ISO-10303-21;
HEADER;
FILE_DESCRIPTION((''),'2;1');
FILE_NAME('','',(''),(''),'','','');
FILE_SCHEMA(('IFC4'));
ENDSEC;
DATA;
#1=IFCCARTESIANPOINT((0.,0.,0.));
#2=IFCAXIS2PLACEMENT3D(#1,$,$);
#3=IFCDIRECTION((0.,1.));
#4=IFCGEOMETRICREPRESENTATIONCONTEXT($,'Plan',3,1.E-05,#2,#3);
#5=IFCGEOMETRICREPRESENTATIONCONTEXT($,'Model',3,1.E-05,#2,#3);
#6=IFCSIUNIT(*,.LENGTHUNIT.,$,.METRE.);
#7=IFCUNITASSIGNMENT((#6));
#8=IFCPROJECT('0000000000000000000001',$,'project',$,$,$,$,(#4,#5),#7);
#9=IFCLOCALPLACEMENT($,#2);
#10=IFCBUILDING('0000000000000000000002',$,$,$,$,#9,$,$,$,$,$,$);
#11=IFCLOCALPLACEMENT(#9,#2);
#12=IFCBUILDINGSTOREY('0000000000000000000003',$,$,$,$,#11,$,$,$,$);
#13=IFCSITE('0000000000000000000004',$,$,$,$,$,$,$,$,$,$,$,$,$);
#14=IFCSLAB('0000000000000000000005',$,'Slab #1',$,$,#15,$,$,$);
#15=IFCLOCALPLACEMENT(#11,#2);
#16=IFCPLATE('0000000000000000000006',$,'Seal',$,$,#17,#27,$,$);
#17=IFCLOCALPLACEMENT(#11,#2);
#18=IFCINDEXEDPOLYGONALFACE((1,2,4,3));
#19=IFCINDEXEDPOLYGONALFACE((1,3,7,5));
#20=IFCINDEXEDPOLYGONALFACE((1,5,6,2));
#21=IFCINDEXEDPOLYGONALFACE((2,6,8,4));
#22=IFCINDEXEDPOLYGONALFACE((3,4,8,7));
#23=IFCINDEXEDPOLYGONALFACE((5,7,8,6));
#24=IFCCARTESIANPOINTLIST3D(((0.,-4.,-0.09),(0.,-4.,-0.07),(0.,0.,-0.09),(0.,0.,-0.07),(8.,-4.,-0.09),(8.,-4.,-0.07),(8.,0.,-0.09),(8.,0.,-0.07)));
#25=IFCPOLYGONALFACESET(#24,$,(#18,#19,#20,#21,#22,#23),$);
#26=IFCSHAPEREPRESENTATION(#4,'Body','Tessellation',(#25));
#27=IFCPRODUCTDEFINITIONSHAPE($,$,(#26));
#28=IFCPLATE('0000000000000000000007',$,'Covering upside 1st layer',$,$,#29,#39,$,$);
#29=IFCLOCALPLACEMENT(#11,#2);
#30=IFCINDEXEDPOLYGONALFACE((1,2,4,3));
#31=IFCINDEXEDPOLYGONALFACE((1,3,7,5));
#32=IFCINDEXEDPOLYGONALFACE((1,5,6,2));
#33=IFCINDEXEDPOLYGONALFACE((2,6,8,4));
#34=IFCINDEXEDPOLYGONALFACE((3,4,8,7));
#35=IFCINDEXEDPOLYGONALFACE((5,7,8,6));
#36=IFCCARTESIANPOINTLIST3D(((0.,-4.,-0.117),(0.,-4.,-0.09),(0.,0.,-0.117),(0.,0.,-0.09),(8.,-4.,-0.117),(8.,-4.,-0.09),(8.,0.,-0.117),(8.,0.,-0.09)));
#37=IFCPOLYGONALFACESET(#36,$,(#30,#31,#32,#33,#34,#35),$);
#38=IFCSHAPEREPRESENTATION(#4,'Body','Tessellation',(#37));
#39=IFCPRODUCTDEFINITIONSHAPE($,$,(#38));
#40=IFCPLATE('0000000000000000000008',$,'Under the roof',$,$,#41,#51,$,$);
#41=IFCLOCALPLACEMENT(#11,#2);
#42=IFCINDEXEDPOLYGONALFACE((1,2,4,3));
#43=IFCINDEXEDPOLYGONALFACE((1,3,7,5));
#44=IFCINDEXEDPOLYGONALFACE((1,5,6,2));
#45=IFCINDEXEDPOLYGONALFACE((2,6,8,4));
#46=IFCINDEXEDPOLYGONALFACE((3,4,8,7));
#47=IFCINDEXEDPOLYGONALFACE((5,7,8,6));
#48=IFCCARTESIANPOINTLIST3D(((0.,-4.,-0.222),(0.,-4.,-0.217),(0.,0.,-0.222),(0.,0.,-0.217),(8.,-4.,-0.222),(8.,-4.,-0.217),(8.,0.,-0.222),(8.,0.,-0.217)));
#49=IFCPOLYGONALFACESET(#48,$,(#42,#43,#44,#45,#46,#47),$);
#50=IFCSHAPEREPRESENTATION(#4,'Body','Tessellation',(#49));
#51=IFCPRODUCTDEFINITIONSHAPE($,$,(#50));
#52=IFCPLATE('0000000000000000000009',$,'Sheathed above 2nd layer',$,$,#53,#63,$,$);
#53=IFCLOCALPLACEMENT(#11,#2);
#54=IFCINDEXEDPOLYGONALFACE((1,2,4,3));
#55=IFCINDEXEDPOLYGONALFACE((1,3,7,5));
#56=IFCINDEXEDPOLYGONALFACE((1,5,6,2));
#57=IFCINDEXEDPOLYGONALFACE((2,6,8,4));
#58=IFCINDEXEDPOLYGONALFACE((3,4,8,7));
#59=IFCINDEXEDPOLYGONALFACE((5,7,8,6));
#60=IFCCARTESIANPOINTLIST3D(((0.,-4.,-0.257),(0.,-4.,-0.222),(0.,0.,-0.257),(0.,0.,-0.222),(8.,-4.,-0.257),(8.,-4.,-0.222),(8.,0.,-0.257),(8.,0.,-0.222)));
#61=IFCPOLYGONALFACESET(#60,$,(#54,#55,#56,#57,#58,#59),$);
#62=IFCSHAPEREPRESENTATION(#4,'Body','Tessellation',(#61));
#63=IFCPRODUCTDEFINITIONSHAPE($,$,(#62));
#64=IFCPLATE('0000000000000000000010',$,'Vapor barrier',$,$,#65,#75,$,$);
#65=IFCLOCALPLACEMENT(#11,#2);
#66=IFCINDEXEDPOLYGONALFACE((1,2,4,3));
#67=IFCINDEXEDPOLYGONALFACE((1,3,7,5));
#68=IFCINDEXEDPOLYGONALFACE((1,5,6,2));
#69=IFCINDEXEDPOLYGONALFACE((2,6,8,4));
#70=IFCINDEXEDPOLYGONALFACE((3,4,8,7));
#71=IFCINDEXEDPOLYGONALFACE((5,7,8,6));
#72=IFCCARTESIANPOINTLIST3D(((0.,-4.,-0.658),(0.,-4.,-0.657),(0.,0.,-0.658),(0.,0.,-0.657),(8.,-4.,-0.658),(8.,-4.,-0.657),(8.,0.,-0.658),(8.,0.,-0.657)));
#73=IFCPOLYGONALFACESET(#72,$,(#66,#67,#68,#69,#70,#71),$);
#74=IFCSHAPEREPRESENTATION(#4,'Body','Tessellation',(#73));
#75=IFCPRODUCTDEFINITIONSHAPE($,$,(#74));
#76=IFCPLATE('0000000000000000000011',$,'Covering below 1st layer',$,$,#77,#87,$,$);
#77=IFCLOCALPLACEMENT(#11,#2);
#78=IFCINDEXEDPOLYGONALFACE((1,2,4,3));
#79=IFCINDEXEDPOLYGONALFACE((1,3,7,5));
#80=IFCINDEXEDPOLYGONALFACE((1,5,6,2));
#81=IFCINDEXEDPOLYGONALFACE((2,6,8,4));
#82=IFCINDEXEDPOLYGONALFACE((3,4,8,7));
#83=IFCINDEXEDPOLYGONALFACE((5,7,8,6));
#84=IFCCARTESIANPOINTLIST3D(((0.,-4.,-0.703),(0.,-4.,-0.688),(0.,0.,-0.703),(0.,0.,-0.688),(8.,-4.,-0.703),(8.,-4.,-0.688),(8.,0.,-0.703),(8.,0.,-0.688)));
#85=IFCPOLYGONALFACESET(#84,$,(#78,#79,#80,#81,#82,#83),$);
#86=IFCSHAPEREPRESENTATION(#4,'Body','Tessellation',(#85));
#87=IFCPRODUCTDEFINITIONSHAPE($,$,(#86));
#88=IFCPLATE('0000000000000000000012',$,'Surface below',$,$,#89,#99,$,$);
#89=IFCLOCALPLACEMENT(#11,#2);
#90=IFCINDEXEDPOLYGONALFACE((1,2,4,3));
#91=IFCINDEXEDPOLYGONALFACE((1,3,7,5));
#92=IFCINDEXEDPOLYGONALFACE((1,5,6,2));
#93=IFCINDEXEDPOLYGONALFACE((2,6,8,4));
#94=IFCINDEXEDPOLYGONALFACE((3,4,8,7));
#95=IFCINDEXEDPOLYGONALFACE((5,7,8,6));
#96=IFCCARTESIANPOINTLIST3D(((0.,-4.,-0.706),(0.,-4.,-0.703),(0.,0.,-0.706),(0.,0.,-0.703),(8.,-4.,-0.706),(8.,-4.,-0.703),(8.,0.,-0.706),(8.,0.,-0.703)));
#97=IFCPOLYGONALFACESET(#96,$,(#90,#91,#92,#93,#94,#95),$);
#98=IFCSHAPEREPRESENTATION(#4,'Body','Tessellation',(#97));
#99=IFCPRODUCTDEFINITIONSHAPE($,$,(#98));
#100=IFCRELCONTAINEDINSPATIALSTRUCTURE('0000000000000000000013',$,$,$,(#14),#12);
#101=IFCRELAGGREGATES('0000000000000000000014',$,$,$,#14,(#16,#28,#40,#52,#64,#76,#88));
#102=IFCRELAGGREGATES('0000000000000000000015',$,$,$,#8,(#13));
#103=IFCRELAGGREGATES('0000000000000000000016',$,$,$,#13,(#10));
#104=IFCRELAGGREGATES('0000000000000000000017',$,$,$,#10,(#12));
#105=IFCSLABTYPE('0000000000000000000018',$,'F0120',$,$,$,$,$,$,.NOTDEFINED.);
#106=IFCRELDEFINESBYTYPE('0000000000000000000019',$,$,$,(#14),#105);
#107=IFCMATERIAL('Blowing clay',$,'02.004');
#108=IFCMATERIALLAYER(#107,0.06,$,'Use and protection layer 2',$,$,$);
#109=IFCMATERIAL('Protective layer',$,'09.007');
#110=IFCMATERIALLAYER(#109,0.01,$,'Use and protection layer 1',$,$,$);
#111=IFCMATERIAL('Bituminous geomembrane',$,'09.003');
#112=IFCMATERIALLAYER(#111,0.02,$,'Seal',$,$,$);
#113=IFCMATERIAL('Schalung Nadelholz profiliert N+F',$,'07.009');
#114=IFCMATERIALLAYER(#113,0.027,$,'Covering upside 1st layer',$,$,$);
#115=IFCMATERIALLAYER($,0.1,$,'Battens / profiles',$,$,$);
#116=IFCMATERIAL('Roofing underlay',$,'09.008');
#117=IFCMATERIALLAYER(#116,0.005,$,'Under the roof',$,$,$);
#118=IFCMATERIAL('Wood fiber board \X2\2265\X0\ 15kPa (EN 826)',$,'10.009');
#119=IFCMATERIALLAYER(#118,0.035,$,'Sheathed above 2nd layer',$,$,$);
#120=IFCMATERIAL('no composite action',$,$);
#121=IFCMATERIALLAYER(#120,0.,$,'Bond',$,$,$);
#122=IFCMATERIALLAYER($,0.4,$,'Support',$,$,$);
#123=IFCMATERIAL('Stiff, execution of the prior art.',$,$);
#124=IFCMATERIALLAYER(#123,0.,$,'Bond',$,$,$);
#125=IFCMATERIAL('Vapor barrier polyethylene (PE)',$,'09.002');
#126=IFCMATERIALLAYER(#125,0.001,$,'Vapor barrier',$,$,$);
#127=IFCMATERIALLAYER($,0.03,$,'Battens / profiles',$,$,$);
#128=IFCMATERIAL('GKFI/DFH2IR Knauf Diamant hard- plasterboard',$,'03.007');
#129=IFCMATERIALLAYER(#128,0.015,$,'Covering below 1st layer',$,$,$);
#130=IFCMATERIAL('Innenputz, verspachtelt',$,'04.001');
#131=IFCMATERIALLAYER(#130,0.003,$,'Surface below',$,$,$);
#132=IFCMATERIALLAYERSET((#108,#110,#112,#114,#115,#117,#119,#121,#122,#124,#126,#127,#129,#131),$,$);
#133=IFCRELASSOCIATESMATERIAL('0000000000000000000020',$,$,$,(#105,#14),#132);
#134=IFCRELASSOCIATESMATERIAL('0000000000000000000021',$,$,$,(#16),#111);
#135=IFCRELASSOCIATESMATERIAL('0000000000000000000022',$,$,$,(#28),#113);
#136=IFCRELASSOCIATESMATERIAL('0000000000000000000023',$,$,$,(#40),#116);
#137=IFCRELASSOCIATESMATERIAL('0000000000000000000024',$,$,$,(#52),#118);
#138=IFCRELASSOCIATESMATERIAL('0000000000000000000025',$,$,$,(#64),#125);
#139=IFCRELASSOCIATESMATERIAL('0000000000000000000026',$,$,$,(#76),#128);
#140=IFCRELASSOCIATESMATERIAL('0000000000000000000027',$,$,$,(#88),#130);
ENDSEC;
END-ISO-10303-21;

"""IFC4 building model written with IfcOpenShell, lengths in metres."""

from ifc_helpers import new_model, si_unit, direction, frame, frame_2d, origin, place, context, project, spatial, rectangle, extrude, material, layer, layer_set, type_object, element, aggregate, save


model = new_model("IFC4")

# Units and contexts
plan_context = context("Plan", 3, precision=1e-05, world=origin(), true_north=direction((0.0, 1.0)))
model_context = context("Model", 3, precision=1e-05, world=origin(), true_north=direction((0.0, 1.0)))
ifc_project = project(units=[si_unit("LENGTHUNIT", "METRE")], contexts=[plan_context, model_context])

# Site, building, storey
site = spatial("IfcSite", under=ifc_project)
building_placement = place(None, origin())
building = spatial("IfcBuilding", under=site, at=building_placement)
storey_placement = place(building_placement, origin())
storey = spatial("IfcBuildingStorey", under=building, at=storey_placement)

# Slab, plates
ifc_material_1 = material(Name="Blowing clay", Category="02.004")
ifc_layer_1 = layer(ifc_material_1, 0.06, Name="Use and protection layer 2")
ifc_material_2 = material(Name="Protective layer", Category="09.007")
ifc_layer_2 = layer(ifc_material_2, 0.01, Name="Use and protection layer 1")
ifc_material_3 = material(Name="Bituminous geomembrane", Category="09.003")
ifc_layer_3 = layer(ifc_material_3, 0.02, Name="Seal")
ifc_material_4 = material(Name="Schalung Nadelholz profiliert N+F", Category="07.009")
ifc_layer_4 = layer(ifc_material_4, 0.027, Name="Covering upside 1st layer")
ifc_layer_5 = layer(None, 0.1, Name="Battens / profiles")
ifc_material_5 = material(Name="Roofing underlay", Category="09.008")
ifc_layer_6 = layer(ifc_material_5, 0.005, Name="Under the roof")
ifc_material_6 = material(Name="Wood fiber board ≥ 15kPa (EN 826)", Category="10.009")
ifc_layer_7 = layer(ifc_material_6, 0.035, Name="Sheathed above 2nd layer")
ifc_material_7 = material(Name="no composite action")
ifc_layer_8 = layer(ifc_material_7, 0.0, Name="Bond")
ifc_layer_9 = layer(None, 0.4, Name="Support")
ifc_material_8 = material(Name="Stiff, execution of the prior art.")
ifc_layer_10 = layer(ifc_material_8, 0.0, Name="Bond")
ifc_material_9 = material(Name="Vapor barrier polyethylene (PE)", Category="09.002")
ifc_layer_11 = layer(ifc_material_9, 0.001, Name="Vapor barrier")
ifc_layer_12 = layer(None, 0.03, Name="Battens / profiles")
ifc_material_10 = material(Name="GKFI/DFH2IR Knauf Diamant hard- plasterboard", Category="03.007")
ifc_layer_13 = layer(ifc_material_10, 0.015, Name="Covering below 1st layer")
ifc_material_11 = material(Name="Innenputz, verspachtelt", Category="04.001")
ifc_layer_14 = layer(ifc_material_11, 0.003, Name="Surface below")
ifc_layer_set = layer_set([ifc_layer_1, ifc_layer_2, ifc_layer_3, ifc_layer_4, ifc_layer_5, ifc_layer_6, ifc_layer_7, ifc_layer_8, ifc_layer_9, ifc_layer_10, ifc_layer_11, ifc_layer_12, ifc_layer_13, ifc_layer_14])
slab_type = type_object("IfcSlabType", Name="F0120", PredefinedType="NOTDEFINED", material=ifc_layer_set)
slab_placement = place(None, frame((0.0, 0.0, 0.0), z_axis=(0.0, 0.0, -1.0), x_axis=(1.0, 0.0, 0.0)))
slab = element("IfcSlab", 1, at=slab_placement, inside=storey, type_object=slab_type, material=ifc_layer_set, Name="Slab #1")
plate_1_placement = place(slab_placement, origin())
plate_1 = element("IfcPlate", 2, at=plate_1_placement, material=ifc_material_3, Name="Seal", context=plan_context, shape_type="SweptSolid", body=[
    extrude(rectangle(XDim=8.0, YDim=4.0, at=frame_2d((4.0, 2.0), x_axis=(1.0, 0.0))), frame((0.0, 0.0, 0.07), z_axis=(0.0, 0.0, 1.0), x_axis=(1.0, 0.0, 0.0)), (0.0, 0.0, 1.0), 0.02),
])
plate_2_placement = place(slab_placement, origin())
plate_2 = element("IfcPlate", 3, at=plate_2_placement, material=ifc_material_4, Name="Covering upside 1st layer", context=plan_context, shape_type="SweptSolid", body=[
    extrude(rectangle(XDim=8.0, YDim=4.0, at=frame_2d((4.0, 2.0), x_axis=(1.0, 0.0))), frame((0.0, 0.0, 0.09), z_axis=(0.0, 0.0, 1.0), x_axis=(1.0, 0.0, 0.0)), (0.0, 0.0, 1.0), 0.027),
])
plate_3_placement = place(slab_placement, origin())
plate_3 = element("IfcPlate", 4, at=plate_3_placement, material=ifc_material_5, Name="Under the roof", context=plan_context, shape_type="SweptSolid", body=[
    extrude(rectangle(XDim=8.0, YDim=4.0, at=frame_2d((4.0, 2.0), x_axis=(1.0, 0.0))), frame((0.0, 0.0, 0.217), z_axis=(0.0, 0.0, 1.0), x_axis=(1.0, 0.0, 0.0)), (0.0, 0.0, 1.0), 0.005),
])
plate_4_placement = place(slab_placement, origin())
plate_4 = element("IfcPlate", 5, at=plate_4_placement, material=ifc_material_6, Name="Sheathed above 2nd layer", context=plan_context, shape_type="SweptSolid", body=[
    extrude(rectangle(XDim=8.0, YDim=4.0, at=frame_2d((4.0, 2.0), x_axis=(1.0, 0.0))), frame((0.0, 0.0, 0.222), z_axis=(0.0, 0.0, 1.0), x_axis=(1.0, 0.0, 0.0)), (0.0, 0.0, 1.0), 0.035),
])
plate_5_placement = place(slab_placement, origin())
plate_5 = element("IfcPlate", 6, at=plate_5_placement, material=ifc_material_9, Name="Vapor barrier", context=plan_context, shape_type="SweptSolid", body=[
    extrude(rectangle(XDim=8.0, YDim=4.0, at=frame_2d((4.0, 2.0), x_axis=(1.0, 0.0))), frame((0.0, 0.0, 0.657), z_axis=(0.0, 0.0, 1.0), x_axis=(1.0, 0.0, 0.0)), (0.0, 0.0, 1.0), 0.001),
])
plate_6_placement = place(slab_placement, origin())
plate_6 = element("IfcPlate", 7, at=plate_6_placement, material=ifc_material_10, Name="Covering below 1st layer", context=plan_context, shape_type="SweptSolid", body=[
    extrude(rectangle(XDim=8.0, YDim=4.0, at=frame_2d((4.0, 2.0), x_axis=(1.0, 0.0))), frame((0.0, 0.0, 0.688), z_axis=(0.0, 0.0, 1.0), x_axis=(1.0, 0.0, 0.0)), (0.0, 0.0, 1.0), 0.015),
])
plate_7_placement = place(slab_placement, origin())
plate_7 = element("IfcPlate", 8, at=plate_7_placement, material=ifc_material_11, Name="Surface below", context=plan_context, shape_type="SweptSolid", body=[
    extrude(rectangle(XDim=8.0, YDim=4.0, at=frame_2d((4.0, 2.0), x_axis=(1.0, 0.0))), frame((0.0, 0.0, 0.703), z_axis=(0.0, 0.0, 1.0), x_axis=(1.0, 0.0, 0.0)), (0.0, 0.0, 1.0), 0.003),
])
aggregate(slab, [plate_1, plate_2, plate_3, plate_4, plate_5, plate_6, plate_7])

save(model, "model.ifc")
